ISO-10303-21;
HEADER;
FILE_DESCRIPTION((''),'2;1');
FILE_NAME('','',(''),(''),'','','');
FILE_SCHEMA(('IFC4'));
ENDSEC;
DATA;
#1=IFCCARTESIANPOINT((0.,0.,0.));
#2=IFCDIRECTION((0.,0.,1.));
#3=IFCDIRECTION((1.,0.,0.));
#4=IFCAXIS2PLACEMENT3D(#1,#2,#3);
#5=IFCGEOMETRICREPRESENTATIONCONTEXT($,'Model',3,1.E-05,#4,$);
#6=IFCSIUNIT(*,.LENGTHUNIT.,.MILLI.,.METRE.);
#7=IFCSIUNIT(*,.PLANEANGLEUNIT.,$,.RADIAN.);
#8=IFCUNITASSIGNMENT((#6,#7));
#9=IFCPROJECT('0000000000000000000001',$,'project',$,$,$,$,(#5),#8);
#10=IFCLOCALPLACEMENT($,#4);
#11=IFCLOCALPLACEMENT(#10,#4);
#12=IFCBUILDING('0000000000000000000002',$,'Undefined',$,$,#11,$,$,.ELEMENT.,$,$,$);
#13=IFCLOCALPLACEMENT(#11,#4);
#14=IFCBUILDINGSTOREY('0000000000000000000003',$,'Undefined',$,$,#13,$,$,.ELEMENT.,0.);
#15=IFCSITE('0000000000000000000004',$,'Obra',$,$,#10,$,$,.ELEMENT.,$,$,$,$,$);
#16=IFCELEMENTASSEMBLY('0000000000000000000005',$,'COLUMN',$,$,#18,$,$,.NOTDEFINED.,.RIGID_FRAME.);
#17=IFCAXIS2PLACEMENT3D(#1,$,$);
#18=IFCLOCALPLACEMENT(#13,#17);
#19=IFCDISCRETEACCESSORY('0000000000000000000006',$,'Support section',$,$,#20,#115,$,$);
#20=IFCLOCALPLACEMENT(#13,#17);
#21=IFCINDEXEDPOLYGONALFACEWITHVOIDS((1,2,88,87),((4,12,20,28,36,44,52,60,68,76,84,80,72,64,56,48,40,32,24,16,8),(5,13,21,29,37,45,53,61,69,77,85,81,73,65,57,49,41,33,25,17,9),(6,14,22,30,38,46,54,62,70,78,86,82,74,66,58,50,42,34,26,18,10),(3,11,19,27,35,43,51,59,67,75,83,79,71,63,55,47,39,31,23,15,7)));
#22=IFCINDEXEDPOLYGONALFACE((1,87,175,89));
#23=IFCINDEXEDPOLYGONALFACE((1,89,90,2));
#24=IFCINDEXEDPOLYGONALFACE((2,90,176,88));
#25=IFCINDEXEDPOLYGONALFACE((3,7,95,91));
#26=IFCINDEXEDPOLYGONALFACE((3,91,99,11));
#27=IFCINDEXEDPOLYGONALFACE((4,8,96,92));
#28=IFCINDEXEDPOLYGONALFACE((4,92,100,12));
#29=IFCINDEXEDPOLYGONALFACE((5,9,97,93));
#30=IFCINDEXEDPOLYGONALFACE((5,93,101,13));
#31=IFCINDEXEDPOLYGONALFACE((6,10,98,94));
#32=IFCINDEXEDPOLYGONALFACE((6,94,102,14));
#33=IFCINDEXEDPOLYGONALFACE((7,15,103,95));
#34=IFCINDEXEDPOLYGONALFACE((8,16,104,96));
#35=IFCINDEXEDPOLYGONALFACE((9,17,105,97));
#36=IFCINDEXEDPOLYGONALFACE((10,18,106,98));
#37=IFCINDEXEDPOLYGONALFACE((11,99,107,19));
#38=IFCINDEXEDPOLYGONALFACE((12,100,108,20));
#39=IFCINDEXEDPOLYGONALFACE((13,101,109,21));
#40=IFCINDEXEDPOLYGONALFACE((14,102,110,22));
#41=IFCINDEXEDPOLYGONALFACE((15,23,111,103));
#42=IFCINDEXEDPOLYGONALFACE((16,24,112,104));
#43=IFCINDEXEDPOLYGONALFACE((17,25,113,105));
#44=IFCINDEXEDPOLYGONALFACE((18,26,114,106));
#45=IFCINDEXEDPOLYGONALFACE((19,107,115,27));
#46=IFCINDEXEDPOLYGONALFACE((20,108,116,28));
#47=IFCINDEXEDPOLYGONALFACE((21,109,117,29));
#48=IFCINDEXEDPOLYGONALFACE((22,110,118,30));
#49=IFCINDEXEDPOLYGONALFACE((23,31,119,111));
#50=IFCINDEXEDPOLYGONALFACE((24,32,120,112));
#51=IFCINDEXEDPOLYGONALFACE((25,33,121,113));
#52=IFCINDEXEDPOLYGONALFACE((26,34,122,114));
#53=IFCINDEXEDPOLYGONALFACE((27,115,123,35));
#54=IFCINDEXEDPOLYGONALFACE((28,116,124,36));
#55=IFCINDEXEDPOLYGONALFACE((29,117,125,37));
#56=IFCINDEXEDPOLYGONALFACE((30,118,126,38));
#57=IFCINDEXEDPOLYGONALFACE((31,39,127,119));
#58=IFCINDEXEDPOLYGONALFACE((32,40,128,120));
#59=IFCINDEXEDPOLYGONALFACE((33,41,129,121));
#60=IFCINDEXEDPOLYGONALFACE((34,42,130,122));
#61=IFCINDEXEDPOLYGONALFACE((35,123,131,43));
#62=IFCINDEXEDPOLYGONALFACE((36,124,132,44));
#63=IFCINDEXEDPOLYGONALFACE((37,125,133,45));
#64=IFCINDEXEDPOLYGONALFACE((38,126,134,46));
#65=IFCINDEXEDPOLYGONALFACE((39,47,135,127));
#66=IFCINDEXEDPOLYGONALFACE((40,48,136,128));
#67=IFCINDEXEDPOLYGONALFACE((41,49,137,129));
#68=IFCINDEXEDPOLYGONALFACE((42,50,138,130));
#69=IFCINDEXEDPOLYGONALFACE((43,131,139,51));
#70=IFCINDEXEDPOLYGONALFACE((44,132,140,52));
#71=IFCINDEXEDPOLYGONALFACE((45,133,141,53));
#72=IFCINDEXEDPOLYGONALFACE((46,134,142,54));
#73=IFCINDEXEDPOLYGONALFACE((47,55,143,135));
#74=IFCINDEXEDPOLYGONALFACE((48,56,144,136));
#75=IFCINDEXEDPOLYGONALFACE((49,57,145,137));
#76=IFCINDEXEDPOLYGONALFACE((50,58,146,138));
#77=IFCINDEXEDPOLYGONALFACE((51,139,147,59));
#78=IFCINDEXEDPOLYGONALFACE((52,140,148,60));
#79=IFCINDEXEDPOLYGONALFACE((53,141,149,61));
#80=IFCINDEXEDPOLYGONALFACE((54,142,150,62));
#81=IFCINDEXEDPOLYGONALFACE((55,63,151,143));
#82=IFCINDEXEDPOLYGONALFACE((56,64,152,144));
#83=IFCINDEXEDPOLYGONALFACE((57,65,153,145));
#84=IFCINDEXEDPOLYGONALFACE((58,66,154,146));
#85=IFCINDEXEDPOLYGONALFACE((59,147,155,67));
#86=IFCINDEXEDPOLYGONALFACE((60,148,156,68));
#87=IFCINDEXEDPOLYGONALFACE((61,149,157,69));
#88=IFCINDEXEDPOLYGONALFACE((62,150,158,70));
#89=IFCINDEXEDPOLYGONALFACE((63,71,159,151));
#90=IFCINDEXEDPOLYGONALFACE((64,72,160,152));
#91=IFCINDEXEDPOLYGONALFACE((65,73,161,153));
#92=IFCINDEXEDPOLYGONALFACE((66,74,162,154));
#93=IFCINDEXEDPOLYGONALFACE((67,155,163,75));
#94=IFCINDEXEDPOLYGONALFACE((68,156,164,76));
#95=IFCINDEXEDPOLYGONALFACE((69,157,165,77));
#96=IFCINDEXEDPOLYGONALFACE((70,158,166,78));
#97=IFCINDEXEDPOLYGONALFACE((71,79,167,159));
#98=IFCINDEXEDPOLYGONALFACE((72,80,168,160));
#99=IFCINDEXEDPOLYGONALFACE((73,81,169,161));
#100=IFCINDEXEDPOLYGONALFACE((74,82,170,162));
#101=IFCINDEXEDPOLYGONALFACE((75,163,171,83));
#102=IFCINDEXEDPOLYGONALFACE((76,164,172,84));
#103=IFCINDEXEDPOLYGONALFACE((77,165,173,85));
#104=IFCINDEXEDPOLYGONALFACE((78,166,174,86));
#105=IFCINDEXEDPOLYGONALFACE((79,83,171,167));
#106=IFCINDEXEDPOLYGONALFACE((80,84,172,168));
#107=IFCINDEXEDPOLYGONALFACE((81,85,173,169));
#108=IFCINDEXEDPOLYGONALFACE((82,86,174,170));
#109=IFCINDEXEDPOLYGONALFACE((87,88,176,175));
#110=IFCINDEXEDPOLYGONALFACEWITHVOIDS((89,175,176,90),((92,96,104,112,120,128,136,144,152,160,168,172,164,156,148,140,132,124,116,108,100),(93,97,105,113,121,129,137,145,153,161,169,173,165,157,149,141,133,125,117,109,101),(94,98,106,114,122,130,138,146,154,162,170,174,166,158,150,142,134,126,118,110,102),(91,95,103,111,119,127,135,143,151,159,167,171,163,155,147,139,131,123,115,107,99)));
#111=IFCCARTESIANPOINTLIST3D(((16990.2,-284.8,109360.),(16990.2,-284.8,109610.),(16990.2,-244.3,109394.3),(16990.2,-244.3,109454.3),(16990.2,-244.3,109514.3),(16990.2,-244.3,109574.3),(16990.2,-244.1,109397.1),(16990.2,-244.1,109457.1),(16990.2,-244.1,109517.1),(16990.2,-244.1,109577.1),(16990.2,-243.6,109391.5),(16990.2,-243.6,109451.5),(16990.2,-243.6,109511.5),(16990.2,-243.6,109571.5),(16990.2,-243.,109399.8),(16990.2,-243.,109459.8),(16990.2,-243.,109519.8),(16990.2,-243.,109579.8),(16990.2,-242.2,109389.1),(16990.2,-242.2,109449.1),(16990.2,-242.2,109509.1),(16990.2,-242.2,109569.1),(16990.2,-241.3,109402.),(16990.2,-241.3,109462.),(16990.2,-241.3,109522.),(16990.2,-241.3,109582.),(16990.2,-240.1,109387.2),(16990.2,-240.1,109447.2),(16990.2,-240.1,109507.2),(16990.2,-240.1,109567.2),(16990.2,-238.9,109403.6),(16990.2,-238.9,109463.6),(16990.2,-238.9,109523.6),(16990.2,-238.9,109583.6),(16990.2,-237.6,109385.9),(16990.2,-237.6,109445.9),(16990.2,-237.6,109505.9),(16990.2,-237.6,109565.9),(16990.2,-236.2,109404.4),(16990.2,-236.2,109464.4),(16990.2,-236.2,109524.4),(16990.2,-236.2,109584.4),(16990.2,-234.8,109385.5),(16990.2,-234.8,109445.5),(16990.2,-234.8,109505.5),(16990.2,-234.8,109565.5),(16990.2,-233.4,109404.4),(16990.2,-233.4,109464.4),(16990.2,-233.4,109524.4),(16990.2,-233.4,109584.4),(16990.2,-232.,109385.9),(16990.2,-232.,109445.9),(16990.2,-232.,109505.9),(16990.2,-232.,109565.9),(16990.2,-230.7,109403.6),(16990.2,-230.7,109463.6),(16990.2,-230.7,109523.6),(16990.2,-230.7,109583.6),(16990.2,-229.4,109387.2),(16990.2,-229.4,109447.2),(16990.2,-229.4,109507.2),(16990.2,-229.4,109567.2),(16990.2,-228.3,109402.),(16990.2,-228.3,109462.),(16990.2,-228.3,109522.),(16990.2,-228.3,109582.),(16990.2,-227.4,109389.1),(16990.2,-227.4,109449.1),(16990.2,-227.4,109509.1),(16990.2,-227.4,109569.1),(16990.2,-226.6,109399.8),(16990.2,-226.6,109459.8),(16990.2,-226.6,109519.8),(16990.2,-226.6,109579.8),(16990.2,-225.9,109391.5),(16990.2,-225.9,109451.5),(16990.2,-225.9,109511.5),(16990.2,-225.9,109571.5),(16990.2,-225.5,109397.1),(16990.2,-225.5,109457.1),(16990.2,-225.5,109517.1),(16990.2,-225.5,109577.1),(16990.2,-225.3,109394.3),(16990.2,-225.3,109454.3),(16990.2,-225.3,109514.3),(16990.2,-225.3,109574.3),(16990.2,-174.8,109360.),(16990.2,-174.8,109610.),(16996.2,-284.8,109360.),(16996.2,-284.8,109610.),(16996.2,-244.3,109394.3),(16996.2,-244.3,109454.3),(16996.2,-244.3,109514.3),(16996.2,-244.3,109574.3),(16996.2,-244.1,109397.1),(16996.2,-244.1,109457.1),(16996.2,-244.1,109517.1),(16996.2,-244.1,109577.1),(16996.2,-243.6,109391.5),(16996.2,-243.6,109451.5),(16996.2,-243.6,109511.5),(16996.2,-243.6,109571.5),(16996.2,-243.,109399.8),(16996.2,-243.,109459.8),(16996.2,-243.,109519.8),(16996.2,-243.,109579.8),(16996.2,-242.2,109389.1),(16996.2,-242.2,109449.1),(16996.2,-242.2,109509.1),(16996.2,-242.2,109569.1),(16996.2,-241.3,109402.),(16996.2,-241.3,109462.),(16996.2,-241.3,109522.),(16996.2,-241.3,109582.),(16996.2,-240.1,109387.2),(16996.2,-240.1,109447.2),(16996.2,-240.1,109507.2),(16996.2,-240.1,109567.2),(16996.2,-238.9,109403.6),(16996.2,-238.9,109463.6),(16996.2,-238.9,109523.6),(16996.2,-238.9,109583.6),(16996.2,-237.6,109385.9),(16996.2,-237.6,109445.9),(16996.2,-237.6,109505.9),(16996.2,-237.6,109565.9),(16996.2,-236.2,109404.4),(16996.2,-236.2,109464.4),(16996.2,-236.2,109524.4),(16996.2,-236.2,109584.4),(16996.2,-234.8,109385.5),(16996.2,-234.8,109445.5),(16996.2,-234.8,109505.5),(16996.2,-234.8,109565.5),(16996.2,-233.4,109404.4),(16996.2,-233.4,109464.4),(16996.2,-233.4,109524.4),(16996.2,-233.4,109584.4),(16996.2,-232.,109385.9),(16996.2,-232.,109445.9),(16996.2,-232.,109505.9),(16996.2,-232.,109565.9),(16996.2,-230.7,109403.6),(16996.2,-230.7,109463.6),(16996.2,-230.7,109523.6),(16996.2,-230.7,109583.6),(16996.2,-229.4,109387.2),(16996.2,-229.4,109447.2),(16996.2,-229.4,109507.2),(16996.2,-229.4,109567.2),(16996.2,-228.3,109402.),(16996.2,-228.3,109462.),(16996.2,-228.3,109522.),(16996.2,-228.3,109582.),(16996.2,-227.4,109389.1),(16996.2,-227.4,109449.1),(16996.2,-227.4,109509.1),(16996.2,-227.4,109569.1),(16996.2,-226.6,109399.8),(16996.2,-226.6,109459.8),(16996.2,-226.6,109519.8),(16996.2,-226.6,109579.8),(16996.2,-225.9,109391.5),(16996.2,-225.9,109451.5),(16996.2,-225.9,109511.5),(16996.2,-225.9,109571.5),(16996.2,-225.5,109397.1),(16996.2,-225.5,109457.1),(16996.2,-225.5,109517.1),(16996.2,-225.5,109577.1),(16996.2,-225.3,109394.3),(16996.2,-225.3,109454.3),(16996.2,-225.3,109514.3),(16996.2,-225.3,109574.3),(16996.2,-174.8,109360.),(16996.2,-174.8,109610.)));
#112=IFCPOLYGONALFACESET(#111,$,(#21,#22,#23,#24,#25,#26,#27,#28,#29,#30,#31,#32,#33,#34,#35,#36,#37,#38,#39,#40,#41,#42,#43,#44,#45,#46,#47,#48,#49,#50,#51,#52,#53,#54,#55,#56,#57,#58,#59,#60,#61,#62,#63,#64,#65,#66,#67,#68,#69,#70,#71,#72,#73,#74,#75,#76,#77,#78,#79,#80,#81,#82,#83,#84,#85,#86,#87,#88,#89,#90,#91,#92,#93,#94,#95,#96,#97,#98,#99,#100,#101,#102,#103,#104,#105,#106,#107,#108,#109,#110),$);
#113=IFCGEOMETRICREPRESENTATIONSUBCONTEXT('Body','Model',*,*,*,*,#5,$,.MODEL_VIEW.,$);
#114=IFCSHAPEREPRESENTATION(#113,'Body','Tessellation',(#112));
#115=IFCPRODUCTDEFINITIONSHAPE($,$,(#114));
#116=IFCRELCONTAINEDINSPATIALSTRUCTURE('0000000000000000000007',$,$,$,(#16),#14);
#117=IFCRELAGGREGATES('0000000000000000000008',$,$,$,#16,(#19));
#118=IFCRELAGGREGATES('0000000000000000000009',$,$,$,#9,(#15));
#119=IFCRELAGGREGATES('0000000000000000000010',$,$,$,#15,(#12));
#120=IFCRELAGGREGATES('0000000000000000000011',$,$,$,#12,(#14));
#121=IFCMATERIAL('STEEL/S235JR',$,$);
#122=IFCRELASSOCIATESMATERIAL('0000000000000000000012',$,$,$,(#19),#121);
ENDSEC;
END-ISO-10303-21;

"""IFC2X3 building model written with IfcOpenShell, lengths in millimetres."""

from ifc_helpers import new_model, si_unit, frame, origin_with_axes, origin_2d_with_axis, place, context, subcontext, project, spatial, rectangle, circle, extrude, source, transform, mapped, material, element, aggregate, save


model = new_model("IFC2X3")

# Units and contexts
model_context = context("Model", 3, precision=1e-05, world=origin_with_axes())
body_context = subcontext(model_context, "Body", "Model", "MODEL_VIEW")
ifc_project = project(units=[si_unit("LENGTHUNIT", "METRE", prefix="MILLI"), si_unit("PLANEANGLEUNIT", "RADIAN")], contexts=[model_context])

# Site, building, storey
site_placement = place(None, origin_with_axes())
site = spatial("IfcSite", under=ifc_project, at=site_placement, Name="Obra", CompositionType="ELEMENT")
building_placement = place(site_placement, origin_with_axes())
building = spatial("IfcBuilding", under=site, at=building_placement, Name="Undefined", CompositionType="ELEMENT")
storey_placement = place(building_placement, origin_with_axes())
storey = spatial("IfcBuildingStorey", under=building, at=storey_placement, Name="Undefined", CompositionType="ELEMENT", Elevation=0.0)

# Shared definitions
ifc_material_1 = material(Name="STEEL/S235JR")

# Element assembly, discrete accessory, opening
assembly_1_placement = place(storey_placement, origin_with_axes())
assembly_1 = element("IfcElementAssembly", 1, at=assembly_1_placement, inside=storey, Name="COLUMN", AssemblyPlace="NOTDEFINED", PredefinedType="RIGID_FRAME")
shared_shape_1 = source(origin_with_axes(), body_context, "Body", "SweptSolid", [
    extrude(circle(Radius=9.5, at=origin_2d_with_axis()), frame((0.0, -9.9, 0.0), z_axis=(0.0, 1.0, 0.0), x_axis=(1.0, 0.0, 0.0)), (0.0, 0.0, 1.0), 6.2),
])
discrete_accessory_1_placement = place(assembly_1_placement, frame((16993.2, -229.8, 109360.0), z_axis=(0.0, 0.0, 1.0), x_axis=(0.0, 1.0, 0.0)))
discrete_accessory_1 = element("IfcDiscreteAccessory", 2, at=discrete_accessory_1_placement, material=ifc_material_1, Name="Support section", context=body_context, shape_type="SweptSolid", body=[
    extrude(rectangle(XDim=6.0, YDim=110.0, at=origin_2d_with_axis()), frame((0.0, 0.0, 250.0), z_axis=(0.0, 0.0, -1.0), x_axis=(0.0, 1.0, 0.0)), (0.0, 0.0, 1.0), 250.0),
])
opening_1_placement = place(assembly_1_placement, frame((17000.0, -184.8, 109650.0), z_axis=(0.0, -1.0, 0.0), x_axis=(0.0, 0.0, -1.0)))
element("IfcOpeningElement", 3, at=opening_1_placement, cuts=discrete_accessory_1, ObjectType="Opening", context=body_context, shape_type="MappedRepresentation", body=[
    mapped(shared_shape_1, transform((75.0, 0.0, 50.0))),
    mapped(shared_shape_1, transform((135.0, 0.0, 50.0))),
    mapped(shared_shape_1, transform((195.0, 0.0, 50.0))),
    mapped(shared_shape_1, transform((255.0, 0.0, 50.0))),
])
aggregate(assembly_1, [discrete_accessory_1])

save(model, "model.ifc")
